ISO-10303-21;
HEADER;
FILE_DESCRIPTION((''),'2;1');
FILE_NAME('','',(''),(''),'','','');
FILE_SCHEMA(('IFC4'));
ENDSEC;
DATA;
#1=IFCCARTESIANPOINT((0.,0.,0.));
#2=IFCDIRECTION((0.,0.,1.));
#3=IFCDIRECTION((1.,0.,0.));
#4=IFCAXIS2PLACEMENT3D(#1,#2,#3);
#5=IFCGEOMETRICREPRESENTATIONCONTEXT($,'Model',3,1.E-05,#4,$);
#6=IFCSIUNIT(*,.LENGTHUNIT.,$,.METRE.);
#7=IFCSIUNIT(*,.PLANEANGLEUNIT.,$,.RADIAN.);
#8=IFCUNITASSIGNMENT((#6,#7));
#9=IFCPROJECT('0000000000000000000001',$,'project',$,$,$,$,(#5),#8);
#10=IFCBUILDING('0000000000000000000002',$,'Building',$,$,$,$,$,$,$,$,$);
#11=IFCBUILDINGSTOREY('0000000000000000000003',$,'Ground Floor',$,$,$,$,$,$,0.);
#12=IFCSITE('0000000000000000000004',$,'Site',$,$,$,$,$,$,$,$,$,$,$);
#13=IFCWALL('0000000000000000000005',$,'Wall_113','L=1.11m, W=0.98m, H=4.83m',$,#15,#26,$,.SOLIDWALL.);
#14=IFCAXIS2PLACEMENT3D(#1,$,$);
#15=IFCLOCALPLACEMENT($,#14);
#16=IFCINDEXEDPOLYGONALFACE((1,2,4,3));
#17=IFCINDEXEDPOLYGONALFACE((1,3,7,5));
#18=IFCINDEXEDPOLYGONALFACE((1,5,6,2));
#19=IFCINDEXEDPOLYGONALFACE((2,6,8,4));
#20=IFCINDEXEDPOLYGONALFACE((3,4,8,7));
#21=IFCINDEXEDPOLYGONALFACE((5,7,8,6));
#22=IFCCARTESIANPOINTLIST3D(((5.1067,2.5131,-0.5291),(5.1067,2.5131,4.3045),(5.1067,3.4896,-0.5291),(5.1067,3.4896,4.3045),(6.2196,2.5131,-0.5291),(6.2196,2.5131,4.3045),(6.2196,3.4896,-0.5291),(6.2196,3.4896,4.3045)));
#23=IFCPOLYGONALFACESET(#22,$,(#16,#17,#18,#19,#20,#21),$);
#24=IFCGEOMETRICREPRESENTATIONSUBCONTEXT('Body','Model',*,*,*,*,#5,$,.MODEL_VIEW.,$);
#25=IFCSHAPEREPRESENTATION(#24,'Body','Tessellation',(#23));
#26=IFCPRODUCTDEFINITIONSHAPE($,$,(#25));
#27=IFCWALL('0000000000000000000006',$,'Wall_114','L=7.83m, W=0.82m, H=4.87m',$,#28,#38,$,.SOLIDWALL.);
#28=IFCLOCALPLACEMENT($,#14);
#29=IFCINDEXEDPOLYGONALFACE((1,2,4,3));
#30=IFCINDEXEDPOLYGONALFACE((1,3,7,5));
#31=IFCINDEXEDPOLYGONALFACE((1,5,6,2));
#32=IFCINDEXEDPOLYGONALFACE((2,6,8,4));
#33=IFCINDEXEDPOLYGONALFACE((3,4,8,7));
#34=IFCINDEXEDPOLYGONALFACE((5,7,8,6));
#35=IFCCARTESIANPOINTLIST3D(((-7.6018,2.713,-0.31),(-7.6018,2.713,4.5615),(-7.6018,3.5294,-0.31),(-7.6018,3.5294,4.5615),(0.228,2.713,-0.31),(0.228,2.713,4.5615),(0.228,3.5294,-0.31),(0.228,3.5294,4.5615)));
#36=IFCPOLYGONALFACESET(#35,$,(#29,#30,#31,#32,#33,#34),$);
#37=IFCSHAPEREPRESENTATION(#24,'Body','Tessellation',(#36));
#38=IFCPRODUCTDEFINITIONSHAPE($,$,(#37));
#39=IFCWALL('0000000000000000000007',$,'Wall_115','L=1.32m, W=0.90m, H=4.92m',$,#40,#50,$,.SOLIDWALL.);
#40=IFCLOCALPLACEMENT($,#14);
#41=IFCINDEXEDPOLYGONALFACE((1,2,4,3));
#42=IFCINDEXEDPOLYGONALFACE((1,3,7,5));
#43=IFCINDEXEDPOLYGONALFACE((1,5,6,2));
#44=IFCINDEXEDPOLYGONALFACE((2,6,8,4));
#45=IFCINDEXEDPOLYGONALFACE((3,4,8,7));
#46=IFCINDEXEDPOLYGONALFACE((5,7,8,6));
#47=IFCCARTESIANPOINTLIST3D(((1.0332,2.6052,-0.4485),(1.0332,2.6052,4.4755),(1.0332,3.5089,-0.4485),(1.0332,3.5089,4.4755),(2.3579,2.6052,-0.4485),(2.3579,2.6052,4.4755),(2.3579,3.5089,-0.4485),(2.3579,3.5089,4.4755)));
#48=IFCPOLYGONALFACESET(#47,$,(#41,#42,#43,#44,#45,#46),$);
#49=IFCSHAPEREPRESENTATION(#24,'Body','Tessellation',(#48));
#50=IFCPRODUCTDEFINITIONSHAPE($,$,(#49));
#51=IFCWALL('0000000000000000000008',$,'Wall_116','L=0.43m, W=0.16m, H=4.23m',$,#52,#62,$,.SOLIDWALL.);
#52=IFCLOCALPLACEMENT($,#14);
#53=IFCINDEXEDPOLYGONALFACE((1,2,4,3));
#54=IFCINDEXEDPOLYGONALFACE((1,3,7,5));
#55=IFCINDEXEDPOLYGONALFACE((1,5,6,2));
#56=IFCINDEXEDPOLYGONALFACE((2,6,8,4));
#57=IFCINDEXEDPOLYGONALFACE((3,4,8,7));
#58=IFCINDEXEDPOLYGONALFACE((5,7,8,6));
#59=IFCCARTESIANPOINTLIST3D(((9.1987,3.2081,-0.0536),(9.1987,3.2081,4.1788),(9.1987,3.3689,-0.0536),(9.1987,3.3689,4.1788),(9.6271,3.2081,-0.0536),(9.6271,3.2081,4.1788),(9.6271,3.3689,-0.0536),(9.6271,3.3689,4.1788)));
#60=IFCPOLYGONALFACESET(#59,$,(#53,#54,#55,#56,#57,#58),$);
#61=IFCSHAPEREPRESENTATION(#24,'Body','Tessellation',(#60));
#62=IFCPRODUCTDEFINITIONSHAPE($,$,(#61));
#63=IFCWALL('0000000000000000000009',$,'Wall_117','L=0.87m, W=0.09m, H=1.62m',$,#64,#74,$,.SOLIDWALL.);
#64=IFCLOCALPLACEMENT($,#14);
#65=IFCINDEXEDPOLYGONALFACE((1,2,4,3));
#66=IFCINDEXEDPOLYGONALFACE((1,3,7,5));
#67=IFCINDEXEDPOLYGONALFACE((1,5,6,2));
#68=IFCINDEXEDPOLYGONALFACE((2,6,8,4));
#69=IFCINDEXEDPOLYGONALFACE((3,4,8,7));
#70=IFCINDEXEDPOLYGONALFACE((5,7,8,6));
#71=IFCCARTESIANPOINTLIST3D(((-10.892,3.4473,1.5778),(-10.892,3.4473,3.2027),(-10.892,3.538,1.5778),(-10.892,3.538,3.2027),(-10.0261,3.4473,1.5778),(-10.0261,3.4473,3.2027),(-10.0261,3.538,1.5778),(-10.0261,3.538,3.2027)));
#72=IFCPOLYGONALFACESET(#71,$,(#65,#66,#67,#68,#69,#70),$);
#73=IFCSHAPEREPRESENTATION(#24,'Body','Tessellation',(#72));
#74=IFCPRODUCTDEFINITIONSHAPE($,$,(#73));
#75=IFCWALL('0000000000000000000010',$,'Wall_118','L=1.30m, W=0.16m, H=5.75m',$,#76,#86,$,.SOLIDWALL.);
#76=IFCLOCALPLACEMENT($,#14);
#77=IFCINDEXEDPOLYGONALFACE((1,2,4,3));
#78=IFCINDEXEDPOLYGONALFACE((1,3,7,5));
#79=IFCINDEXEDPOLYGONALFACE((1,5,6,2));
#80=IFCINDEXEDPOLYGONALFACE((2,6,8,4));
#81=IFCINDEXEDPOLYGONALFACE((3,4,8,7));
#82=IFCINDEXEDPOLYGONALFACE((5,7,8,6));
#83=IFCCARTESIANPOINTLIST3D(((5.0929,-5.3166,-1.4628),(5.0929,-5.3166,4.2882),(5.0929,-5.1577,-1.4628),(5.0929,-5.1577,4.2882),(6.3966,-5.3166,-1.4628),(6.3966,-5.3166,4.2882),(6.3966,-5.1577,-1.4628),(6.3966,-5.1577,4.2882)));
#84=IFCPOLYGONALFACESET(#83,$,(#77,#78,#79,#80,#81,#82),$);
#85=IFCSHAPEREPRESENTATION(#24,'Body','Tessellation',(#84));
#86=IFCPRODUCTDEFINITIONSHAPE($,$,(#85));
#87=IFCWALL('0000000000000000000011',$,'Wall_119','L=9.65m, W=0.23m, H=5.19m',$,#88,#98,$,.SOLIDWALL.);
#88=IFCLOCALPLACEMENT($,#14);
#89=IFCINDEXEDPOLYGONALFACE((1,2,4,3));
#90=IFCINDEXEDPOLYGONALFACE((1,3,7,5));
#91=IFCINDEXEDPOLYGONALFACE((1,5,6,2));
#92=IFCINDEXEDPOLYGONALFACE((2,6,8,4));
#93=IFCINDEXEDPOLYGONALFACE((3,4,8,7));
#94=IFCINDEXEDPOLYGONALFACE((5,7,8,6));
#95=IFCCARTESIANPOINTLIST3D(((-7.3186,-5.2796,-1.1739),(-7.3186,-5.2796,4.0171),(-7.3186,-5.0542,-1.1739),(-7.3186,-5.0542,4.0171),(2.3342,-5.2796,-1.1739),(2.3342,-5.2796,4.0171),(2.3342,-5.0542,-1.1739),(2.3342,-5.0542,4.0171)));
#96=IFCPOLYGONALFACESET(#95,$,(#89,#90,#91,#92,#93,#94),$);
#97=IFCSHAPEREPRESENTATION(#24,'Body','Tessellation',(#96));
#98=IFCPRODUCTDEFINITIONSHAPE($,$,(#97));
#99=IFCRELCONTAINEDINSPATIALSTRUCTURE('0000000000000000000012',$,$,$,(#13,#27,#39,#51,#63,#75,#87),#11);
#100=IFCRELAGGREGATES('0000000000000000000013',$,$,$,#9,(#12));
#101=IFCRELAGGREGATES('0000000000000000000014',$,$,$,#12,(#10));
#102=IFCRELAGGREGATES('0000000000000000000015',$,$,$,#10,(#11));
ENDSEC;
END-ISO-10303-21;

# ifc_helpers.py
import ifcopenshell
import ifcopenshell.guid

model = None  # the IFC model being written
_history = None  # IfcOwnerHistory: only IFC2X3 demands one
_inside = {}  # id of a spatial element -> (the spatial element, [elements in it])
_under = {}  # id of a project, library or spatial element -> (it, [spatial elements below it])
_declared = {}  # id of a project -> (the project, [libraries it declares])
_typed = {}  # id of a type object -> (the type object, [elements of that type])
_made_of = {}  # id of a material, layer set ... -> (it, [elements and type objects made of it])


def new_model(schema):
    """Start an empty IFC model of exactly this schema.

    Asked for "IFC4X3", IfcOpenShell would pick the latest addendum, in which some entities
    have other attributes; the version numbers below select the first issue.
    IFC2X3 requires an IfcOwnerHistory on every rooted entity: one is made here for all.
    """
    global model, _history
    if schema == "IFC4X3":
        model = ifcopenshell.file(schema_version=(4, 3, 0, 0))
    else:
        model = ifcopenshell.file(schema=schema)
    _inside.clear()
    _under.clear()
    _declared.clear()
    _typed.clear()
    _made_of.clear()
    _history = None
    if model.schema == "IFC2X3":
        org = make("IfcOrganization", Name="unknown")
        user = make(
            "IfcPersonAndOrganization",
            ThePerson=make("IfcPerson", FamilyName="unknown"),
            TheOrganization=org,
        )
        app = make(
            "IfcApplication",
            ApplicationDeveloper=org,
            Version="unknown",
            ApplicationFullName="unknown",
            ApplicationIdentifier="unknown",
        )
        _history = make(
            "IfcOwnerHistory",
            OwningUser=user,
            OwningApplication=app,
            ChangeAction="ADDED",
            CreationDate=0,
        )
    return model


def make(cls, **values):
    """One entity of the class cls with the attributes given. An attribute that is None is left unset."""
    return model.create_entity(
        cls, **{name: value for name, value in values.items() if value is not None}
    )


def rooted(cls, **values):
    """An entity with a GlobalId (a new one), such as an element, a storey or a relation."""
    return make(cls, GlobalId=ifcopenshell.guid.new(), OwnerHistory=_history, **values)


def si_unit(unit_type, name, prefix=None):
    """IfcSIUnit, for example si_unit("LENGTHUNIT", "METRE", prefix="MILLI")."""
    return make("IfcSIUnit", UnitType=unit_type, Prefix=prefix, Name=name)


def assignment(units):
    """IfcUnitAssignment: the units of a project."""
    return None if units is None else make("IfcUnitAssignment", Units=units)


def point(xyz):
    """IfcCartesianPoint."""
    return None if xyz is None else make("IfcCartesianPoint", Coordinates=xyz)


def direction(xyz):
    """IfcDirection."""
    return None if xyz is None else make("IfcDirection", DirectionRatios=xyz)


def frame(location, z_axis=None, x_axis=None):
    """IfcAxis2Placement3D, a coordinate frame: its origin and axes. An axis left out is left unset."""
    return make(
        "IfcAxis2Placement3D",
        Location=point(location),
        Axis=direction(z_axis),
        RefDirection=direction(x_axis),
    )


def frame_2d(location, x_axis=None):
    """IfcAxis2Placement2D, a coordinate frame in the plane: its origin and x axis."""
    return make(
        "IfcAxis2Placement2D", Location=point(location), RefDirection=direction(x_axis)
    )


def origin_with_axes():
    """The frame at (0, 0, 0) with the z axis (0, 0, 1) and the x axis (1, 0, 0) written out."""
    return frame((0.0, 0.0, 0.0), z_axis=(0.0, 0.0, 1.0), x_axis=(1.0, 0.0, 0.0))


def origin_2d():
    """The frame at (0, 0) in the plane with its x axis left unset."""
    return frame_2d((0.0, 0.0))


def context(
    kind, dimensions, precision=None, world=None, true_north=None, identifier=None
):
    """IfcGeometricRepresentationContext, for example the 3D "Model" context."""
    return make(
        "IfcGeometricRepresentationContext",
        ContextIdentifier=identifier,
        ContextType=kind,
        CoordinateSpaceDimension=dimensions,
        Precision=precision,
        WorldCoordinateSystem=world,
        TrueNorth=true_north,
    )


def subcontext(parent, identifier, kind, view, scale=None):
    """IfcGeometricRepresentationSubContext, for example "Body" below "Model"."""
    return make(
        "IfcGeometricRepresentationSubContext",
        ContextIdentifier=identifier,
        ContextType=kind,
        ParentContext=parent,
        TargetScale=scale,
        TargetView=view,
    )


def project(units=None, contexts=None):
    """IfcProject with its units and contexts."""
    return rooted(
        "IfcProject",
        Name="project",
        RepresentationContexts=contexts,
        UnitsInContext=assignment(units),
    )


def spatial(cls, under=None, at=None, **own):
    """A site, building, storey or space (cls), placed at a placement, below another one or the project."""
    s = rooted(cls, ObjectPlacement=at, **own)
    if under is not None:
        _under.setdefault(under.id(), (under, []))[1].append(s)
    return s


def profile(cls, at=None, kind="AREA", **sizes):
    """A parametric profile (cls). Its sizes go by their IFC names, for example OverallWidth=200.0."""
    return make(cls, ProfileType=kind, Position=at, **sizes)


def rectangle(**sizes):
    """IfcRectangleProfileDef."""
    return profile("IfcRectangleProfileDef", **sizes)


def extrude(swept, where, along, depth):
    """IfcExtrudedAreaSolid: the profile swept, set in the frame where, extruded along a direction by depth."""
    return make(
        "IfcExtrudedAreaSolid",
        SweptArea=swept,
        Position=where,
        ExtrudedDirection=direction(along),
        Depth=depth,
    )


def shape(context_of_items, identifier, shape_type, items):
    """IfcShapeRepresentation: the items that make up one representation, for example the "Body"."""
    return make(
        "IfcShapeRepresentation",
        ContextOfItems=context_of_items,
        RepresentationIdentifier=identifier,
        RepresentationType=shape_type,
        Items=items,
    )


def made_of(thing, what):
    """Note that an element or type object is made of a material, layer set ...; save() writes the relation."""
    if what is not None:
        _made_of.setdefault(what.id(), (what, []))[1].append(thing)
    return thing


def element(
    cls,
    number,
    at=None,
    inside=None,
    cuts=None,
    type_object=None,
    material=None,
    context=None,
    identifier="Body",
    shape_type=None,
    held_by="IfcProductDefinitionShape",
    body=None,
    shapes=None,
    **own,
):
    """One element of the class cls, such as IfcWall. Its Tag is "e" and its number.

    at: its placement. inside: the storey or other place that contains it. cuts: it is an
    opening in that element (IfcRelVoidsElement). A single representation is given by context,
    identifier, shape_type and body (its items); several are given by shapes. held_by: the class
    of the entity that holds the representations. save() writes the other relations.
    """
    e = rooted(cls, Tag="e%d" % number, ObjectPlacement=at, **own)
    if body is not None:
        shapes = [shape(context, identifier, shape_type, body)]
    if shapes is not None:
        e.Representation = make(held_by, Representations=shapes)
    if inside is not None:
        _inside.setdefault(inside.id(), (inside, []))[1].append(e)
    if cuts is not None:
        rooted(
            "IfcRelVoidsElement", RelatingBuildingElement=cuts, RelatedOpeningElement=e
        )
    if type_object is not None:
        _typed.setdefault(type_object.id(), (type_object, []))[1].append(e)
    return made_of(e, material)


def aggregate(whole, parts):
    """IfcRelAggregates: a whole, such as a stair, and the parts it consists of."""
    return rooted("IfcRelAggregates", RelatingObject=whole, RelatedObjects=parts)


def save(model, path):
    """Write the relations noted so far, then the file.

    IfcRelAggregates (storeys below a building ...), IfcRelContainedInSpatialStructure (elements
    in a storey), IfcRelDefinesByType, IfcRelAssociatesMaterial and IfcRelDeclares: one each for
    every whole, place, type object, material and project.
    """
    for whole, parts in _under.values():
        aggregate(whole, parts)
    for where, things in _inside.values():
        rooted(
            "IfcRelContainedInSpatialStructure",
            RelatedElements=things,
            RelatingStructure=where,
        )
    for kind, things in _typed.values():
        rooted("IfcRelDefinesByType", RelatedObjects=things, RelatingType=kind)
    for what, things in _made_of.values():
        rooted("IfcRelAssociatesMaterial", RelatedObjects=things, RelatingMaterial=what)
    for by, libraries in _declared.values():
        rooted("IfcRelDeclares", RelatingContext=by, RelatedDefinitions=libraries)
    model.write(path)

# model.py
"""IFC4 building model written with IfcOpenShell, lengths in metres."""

from ifc_helpers import new_model, si_unit, frame, origin_with_axes, origin_2d, context, subcontext, project, spatial, rectangle, extrude, element, save


model = new_model("IFC4")

# Units and contexts
model_context = context("Model", 3, precision=1e-05, world=origin_with_axes())
body_context = subcontext(model_context, "Body", "Model", "MODEL_VIEW")
ifc_project = project(units=[si_unit("LENGTHUNIT", "METRE"), si_unit("PLANEANGLEUNIT", "RADIAN")], contexts=[model_context])

# Site, building, storey
site = spatial("IfcSite", under=ifc_project, Name="Site")
building = spatial("IfcBuilding", under=site, Name="Building")
storey = spatial("IfcBuildingStorey", under=building, Name="Ground Floor", Elevation=0.0)

# Walls
element("IfcWall", 1, inside=storey, Name="Wall_113", Description="L=1.11m, W=0.98m, H=4.83m", PredefinedType="SOLIDWALL", context=body_context, shape_type="SweptSolid", body=[
    extrude(rectangle(XDim=1.1129, YDim=0.9766, at=origin_2d()), frame((5.6631, 3.0014, -0.5291), z_axis=(0.0, 0.0, 1.0), x_axis=(1.0, 0.0, 0.0)), (0.0, 0.0, 1.0), 4.8336),
])
element("IfcWall", 2, inside=storey, Name="Wall_114", Description="L=7.83m, W=0.82m, H=4.87m", PredefinedType="SOLIDWALL", context=body_context, shape_type="SweptSolid", body=[
    extrude(rectangle(XDim=7.8298, YDim=0.8164, at=origin_2d()), frame((-3.6869, 3.1212, -0.31), z_axis=(0.0, 0.0, 1.0), x_axis=(1.0, 0.0, 0.0)), (0.0, 0.0, 1.0), 4.8715),
])
element("IfcWall", 3, inside=storey, Name="Wall_115", Description="L=1.32m, W=0.90m, H=4.92m", PredefinedType="SOLIDWALL", context=body_context, shape_type="SweptSolid", body=[
    extrude(rectangle(XDim=1.3247, YDim=0.9036, at=origin_2d()), frame((1.6956, 3.057, -0.4485), z_axis=(0.0, 0.0, 1.0), x_axis=(1.0, 0.0, 0.0)), (0.0, 0.0, 1.0), 4.924),
])
element("IfcWall", 4, inside=storey, Name="Wall_116", Description="L=0.43m, W=0.16m, H=4.23m", PredefinedType="SOLIDWALL", context=body_context, shape_type="SweptSolid", body=[
    extrude(rectangle(XDim=0.4285, YDim=0.1607, at=origin_2d()), frame((9.4129, 3.2885, -0.0536), z_axis=(0.0, 0.0, 1.0), x_axis=(1.0, 0.0, 0.0)), (0.0, 0.0, 1.0), 4.2324),
])
element("IfcWall", 5, inside=storey, Name="Wall_117", Description="L=0.87m, W=0.09m, H=1.62m", PredefinedType="SOLIDWALL", context=body_context, shape_type="SweptSolid", body=[
    extrude(rectangle(XDim=0.8659, YDim=0.0907, at=origin_2d()), frame((-10.4591, 3.4926, 1.5778), z_axis=(0.0, 0.0, 1.0), x_axis=(1.0, 0.0, 0.0)), (0.0, 0.0, 1.0), 1.6249),
])
element("IfcWall", 6, inside=storey, Name="Wall_118", Description="L=1.30m, W=0.16m, H=5.75m", PredefinedType="SOLIDWALL", context=body_context, shape_type="SweptSolid", body=[
    extrude(rectangle(XDim=1.3037, YDim=0.1589, at=origin_2d()), frame((5.7448, -5.2371, -1.4628), z_axis=(0.0, 0.0, 1.0), x_axis=(1.0, 0.0, 0.0)), (0.0, 0.0, 1.0), 5.751),
])
element("IfcWall", 7, inside=storey, Name="Wall_119", Description="L=9.65m, W=0.23m, H=5.19m", PredefinedType="SOLIDWALL", context=body_context, shape_type="SweptSolid", body=[
    extrude(rectangle(XDim=9.6528, YDim=0.2254, at=origin_2d()), frame((-2.4922, -5.1669, -1.1739), z_axis=(0.0, 0.0, 1.0), x_axis=(1.0, 0.0, 0.0)), (0.0, 0.0, 1.0), 5.191),
])

save(model, "model.ifc")
